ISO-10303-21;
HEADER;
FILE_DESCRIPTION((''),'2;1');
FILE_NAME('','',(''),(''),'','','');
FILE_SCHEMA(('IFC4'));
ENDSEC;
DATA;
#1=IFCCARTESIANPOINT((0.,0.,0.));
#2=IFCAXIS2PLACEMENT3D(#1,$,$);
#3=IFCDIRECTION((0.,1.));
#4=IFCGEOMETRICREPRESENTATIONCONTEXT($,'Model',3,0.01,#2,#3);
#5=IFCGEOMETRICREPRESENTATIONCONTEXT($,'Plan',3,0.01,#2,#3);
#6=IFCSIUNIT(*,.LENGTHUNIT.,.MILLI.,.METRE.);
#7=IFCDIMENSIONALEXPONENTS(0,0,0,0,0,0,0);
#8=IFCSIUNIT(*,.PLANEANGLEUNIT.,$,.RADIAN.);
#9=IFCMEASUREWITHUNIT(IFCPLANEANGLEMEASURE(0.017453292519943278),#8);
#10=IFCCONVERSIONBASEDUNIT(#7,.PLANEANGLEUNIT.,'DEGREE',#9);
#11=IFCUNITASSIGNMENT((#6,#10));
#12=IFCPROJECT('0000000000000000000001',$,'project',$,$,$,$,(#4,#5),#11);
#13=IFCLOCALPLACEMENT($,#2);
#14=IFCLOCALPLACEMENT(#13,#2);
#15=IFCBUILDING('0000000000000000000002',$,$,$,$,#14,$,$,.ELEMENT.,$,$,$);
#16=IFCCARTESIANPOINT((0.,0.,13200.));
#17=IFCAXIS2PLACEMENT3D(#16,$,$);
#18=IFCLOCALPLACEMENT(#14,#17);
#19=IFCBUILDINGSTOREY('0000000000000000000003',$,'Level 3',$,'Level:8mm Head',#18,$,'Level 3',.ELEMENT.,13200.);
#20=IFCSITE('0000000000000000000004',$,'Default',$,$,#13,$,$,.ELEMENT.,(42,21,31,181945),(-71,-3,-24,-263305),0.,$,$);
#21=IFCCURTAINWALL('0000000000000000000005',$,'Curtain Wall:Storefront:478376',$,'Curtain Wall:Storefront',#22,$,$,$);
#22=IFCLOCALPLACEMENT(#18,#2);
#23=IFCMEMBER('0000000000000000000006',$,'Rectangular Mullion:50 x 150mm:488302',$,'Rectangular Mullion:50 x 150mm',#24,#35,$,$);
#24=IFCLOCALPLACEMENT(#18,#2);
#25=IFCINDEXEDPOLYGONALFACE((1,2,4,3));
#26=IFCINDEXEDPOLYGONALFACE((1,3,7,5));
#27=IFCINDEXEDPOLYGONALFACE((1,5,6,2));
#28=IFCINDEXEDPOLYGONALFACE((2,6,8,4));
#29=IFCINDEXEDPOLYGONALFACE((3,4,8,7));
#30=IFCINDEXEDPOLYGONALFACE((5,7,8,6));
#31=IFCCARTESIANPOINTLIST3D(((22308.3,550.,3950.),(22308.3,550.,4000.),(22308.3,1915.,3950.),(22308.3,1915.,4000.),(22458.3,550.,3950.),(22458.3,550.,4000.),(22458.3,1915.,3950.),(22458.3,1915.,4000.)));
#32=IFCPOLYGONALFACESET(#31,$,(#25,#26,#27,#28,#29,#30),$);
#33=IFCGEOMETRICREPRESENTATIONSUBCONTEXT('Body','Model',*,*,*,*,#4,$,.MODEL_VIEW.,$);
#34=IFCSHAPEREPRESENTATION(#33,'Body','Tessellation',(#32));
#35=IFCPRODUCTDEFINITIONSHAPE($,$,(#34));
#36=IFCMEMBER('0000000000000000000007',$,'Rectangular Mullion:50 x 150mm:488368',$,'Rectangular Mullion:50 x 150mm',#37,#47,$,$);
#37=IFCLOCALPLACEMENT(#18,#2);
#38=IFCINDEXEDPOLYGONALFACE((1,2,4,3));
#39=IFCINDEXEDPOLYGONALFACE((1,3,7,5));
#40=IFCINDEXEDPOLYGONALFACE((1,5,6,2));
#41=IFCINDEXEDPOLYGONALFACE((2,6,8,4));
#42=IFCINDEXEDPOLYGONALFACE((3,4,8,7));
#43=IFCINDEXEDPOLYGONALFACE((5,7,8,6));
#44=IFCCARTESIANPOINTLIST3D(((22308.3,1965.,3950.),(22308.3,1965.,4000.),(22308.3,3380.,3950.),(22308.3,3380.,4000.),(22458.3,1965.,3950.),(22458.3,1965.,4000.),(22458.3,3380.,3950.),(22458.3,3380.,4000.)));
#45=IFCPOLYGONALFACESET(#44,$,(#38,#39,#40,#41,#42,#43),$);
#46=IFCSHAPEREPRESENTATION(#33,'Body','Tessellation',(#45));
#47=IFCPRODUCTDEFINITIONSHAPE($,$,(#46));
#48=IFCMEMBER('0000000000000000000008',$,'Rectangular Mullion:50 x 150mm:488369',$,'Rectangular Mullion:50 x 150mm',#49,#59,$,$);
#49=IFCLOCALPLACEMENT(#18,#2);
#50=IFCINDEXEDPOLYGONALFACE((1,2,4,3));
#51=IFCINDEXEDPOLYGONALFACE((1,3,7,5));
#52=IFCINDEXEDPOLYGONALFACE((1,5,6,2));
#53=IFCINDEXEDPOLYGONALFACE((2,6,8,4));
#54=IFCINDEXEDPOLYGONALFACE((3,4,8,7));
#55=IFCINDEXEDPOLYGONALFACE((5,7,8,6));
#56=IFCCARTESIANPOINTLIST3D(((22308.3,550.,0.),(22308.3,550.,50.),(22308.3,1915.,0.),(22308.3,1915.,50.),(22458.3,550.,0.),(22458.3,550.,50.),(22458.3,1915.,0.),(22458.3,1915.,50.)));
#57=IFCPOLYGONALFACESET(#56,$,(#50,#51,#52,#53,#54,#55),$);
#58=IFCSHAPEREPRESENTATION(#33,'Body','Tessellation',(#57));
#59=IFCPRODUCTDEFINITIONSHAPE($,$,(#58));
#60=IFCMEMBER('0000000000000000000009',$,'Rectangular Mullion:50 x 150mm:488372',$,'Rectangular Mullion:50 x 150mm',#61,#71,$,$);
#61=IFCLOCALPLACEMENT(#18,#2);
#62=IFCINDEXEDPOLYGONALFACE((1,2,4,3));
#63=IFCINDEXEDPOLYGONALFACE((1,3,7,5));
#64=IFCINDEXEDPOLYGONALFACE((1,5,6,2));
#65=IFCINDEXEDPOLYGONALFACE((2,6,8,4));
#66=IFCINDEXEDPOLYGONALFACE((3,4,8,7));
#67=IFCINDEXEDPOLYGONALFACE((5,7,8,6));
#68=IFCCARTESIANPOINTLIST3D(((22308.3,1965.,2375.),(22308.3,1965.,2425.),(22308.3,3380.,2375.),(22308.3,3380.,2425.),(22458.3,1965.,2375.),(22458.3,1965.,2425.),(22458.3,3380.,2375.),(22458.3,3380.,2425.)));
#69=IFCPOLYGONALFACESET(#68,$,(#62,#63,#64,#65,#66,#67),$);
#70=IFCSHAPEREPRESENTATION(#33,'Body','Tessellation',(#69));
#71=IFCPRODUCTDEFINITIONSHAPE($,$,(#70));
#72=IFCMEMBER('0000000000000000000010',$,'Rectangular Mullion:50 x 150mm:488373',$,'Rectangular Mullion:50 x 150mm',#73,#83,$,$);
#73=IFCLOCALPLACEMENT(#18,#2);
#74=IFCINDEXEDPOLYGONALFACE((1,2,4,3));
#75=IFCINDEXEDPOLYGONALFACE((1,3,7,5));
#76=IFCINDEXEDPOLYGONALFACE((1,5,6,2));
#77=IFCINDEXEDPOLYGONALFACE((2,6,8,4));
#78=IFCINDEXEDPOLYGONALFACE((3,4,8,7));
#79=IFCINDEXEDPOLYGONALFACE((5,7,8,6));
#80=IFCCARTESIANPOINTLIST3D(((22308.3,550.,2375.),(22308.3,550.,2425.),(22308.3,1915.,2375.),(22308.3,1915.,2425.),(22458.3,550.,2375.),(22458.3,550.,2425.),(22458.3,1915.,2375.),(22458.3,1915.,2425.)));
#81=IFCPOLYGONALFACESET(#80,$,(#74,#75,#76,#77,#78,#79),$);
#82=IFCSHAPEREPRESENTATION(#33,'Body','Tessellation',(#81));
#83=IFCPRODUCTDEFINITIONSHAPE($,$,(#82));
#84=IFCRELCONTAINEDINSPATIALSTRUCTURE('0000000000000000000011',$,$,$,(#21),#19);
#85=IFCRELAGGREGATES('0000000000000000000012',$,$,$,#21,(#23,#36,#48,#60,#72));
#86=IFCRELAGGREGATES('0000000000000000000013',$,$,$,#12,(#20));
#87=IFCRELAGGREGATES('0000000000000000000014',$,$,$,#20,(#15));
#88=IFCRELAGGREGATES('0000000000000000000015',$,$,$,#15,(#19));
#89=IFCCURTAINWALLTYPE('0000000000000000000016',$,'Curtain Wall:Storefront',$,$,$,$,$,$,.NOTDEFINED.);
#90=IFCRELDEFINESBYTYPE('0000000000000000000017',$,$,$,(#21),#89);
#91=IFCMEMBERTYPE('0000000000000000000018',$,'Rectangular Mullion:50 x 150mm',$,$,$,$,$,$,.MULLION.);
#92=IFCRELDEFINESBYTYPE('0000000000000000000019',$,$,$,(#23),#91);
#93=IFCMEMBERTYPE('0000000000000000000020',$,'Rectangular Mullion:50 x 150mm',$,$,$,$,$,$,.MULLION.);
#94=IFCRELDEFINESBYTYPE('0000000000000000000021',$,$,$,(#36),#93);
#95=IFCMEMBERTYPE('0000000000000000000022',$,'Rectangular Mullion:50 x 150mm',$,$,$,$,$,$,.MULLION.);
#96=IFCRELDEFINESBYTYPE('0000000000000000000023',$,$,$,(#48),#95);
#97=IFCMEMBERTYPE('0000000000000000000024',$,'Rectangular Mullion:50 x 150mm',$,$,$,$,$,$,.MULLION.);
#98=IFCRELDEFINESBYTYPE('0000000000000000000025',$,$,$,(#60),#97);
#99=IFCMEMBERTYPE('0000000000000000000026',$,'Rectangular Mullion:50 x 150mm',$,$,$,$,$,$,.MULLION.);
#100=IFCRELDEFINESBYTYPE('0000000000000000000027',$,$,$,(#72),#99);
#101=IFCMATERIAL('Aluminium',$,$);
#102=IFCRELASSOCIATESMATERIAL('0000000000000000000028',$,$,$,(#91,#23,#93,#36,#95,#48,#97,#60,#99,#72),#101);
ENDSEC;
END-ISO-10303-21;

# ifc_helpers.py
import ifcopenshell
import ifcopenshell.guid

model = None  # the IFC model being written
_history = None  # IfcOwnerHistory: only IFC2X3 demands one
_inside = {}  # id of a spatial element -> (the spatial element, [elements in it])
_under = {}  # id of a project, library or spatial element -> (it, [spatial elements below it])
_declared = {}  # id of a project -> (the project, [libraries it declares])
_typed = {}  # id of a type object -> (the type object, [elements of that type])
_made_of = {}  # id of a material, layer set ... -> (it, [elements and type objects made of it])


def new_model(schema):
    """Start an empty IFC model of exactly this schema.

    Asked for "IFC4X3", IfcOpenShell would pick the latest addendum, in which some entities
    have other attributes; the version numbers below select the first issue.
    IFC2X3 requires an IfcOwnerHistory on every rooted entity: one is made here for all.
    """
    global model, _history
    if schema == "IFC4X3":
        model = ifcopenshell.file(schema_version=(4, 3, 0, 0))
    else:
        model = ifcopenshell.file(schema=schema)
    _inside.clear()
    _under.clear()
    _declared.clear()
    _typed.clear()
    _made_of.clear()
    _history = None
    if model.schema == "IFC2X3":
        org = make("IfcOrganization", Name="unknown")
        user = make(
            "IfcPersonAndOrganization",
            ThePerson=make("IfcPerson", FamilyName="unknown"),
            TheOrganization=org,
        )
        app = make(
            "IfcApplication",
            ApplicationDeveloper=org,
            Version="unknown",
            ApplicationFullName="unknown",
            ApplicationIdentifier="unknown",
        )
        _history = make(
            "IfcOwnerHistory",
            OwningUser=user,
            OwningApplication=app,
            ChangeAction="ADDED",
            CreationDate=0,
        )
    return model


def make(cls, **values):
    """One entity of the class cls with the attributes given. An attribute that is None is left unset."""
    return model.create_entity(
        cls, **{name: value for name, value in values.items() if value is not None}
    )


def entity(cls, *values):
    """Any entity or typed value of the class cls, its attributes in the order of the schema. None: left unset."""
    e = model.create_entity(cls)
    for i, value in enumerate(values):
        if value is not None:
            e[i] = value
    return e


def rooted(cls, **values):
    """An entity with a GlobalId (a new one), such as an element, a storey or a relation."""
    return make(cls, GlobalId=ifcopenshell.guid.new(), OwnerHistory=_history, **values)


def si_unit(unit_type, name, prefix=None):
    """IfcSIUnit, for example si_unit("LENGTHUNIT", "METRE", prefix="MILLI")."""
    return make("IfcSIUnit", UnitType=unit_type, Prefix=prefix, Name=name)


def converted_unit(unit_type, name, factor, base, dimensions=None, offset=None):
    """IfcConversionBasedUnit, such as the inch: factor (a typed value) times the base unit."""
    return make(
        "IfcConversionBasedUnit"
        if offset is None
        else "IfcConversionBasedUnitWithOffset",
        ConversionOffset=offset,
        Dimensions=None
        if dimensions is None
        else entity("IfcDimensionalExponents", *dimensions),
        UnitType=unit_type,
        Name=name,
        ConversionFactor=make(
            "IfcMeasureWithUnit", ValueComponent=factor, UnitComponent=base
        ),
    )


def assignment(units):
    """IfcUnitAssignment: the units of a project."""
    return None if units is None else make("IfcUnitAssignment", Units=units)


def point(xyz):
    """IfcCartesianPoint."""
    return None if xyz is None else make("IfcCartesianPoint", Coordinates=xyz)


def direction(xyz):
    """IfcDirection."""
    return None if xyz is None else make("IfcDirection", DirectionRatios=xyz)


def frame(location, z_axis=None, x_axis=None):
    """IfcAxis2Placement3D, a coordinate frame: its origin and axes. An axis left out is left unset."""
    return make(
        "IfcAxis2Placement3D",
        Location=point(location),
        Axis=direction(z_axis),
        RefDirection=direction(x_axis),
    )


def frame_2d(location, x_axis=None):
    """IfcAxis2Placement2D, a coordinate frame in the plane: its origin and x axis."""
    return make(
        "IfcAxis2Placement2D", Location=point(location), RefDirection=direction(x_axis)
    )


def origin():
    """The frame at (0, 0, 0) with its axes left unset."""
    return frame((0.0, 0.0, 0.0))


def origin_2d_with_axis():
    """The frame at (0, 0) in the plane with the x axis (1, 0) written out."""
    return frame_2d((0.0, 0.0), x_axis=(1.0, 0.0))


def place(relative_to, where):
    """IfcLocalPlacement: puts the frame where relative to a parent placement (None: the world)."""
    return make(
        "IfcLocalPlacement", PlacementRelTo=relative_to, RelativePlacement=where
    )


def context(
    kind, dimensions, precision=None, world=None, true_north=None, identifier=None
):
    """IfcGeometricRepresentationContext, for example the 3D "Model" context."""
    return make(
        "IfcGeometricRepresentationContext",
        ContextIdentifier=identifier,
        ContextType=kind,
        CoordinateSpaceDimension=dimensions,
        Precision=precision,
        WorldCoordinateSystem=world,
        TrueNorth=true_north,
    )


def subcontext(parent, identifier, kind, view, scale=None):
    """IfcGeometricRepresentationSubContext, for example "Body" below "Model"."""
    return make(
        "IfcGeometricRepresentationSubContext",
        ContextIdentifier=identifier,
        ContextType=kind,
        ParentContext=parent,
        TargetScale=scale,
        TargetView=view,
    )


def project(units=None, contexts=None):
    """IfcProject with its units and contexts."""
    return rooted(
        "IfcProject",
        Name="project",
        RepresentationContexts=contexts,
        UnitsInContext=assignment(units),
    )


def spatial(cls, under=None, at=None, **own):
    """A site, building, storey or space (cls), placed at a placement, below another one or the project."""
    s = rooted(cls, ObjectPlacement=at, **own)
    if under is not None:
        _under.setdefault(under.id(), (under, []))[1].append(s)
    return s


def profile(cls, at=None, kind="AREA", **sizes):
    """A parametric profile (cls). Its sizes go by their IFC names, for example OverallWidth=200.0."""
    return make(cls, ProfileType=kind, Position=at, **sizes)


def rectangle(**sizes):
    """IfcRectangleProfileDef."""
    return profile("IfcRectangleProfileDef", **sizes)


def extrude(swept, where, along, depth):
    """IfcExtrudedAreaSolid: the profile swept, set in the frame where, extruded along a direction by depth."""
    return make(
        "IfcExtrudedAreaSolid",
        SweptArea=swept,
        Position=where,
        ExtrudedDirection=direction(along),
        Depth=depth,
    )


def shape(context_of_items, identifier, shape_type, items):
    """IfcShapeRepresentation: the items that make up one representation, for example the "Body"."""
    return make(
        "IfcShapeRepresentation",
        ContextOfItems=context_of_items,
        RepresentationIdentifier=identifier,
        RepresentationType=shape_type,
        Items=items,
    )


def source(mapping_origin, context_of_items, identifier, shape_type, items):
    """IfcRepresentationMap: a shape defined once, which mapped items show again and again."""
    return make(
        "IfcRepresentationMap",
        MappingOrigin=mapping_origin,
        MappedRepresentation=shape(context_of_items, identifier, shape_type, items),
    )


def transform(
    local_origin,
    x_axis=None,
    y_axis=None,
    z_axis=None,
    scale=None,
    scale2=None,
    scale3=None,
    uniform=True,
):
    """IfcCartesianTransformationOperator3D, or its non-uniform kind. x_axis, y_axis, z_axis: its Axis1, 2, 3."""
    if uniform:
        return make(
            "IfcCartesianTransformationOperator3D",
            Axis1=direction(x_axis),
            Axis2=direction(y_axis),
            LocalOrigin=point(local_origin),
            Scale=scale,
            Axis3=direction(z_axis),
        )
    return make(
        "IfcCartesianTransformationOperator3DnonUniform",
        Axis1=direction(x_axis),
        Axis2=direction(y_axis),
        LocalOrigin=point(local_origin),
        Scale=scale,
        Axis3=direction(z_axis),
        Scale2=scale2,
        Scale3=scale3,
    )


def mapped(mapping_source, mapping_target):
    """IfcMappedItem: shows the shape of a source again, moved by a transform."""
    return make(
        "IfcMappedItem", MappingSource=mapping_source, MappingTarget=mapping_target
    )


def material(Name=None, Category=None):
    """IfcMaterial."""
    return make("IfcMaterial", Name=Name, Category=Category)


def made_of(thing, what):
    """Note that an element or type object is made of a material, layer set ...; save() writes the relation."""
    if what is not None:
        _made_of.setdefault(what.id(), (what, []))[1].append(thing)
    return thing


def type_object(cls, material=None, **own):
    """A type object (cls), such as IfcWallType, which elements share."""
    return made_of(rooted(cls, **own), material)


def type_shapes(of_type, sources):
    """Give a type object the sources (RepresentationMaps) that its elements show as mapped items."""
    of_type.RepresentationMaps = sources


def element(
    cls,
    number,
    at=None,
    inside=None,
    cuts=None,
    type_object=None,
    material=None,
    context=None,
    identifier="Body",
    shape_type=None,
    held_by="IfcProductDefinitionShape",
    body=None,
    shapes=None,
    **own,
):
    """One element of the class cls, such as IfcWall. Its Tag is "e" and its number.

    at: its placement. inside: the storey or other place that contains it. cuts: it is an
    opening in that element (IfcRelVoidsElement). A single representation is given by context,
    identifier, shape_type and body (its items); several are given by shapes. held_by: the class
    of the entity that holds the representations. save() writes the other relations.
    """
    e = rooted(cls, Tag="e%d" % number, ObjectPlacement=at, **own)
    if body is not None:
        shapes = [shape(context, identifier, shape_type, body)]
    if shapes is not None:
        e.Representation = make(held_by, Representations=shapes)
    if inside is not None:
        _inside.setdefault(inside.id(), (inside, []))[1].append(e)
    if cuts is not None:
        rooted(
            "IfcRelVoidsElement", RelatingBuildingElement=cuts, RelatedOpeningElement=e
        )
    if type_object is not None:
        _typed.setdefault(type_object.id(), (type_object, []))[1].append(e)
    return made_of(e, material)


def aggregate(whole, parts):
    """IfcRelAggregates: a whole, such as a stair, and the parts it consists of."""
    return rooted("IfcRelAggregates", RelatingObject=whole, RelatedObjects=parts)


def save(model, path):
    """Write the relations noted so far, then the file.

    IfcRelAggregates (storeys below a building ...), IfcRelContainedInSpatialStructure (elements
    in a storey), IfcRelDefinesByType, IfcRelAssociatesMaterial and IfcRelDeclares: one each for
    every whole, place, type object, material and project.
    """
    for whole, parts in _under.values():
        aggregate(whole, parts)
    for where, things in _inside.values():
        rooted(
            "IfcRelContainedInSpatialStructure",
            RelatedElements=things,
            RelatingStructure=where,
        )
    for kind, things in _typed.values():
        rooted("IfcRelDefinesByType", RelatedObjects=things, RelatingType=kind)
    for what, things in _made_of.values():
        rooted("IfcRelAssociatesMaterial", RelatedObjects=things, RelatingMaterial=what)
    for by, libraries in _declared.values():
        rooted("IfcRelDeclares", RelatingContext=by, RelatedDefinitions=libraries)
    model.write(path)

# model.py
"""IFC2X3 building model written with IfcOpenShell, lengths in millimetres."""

from ifc_helpers import new_model, entity, si_unit, converted_unit, direction, frame, origin, origin_2d_with_axis, place, context, subcontext, project, spatial, rectangle, extrude, source, transform, mapped, material, type_object, type_shapes, element, aggregate, save


model = new_model("IFC2X3")

# Units and contexts
model_context = context("Model", 3, precision=0.01, world=origin(), true_north=direction((0.0, 1.0)))
plan_context = context("Plan", 3, precision=0.01, world=origin(), true_north=direction((0.0, 1.0)))
body_context = subcontext(model_context, "Body", "Model", "MODEL_VIEW")
ifc_project = project(units=[si_unit("LENGTHUNIT", "METRE", prefix="MILLI"), converted_unit("PLANEANGLEUNIT", "DEGREE", entity("IfcPlaneAngleMeasure", 0.017453292519943278), si_unit("PLANEANGLEUNIT", "RADIAN"), dimensions=[0, 0, 0, 0, 0, 0, 0])], contexts=[model_context, plan_context])

# Site, building, storey
site_placement = place(None, origin())
site = spatial("IfcSite", under=ifc_project, at=site_placement, Name="Default", CompositionType="ELEMENT", RefLatitude=(42, 21, 31, 181945), RefLongitude=(-71, -3, -24, -263305), RefElevation=0.0)
building_placement = place(site_placement, origin())
building = spatial("IfcBuilding", under=site, at=building_placement, CompositionType="ELEMENT")
storey_placement = place(building_placement, frame((0.0, 0.0, 13200.0)))
storey = spatial("IfcBuildingStorey", under=building, at=storey_placement, Name="Level 3", ObjectType="Level:8mm Head", LongName="Level 3", CompositionType="ELEMENT", Elevation=13200.0)

# Curtain wall
curtain_wall_type = type_object("IfcCurtainWallType", Name="Curtain Wall:Storefront", PredefinedType="NOTDEFINED")
curtain_wall_1_placement = place(storey_placement, frame((0.0, 0.0, -13200.0)))
curtain_wall_1 = element("IfcCurtainWall", 1, at=curtain_wall_1_placement, inside=storey, type_object=curtain_wall_type, Name="Curtain Wall:Storefront:478376", ObjectType="Curtain Wall:Storefront")
ifc_material_1 = material(Name="Aluminium")

# Members
member_type_1 = type_object("IfcMemberType", Name="Rectangular Mullion:50 x 150mm", PredefinedType="MULLION", material=ifc_material_1)
shared_shape_1 = source(origin(), body_context, "Body", "SweptSolid", [
    extrude(rectangle(XDim=50.0, YDim=150.0, at=origin_2d_with_axis()), frame((-25.0, 0.0, -1365.0), z_axis=(0.0, 0.0, 1.0), x_axis=(-1.0, 0.0, 0.0)), (0.0, 0.0, 1.0), 1365.0),
])
type_shapes(member_type_1, [shared_shape_1])
member_1_placement = place(curtain_wall_1_placement, frame((22383.3, 550.0, 17200.0), z_axis=(0.0, -1.0, 0.0), x_axis=(0.0, 0.0, 1.0)))
member_1 = element("IfcMember", 2, at=member_1_placement, type_object=member_type_1, material=ifc_material_1, Name="Rectangular Mullion:50 x 150mm:488302", ObjectType="Rectangular Mullion:50 x 150mm", context=body_context, shape_type="MappedRepresentation", body=[
    mapped(shared_shape_1, transform((0.0, 0.0, 0.0), scale=1.0)),
])
member_type_2 = type_object("IfcMemberType", Name="Rectangular Mullion:50 x 150mm", PredefinedType="MULLION", material=ifc_material_1)
shared_shape_2 = source(origin(), body_context, "Body", "SweptSolid", [
    extrude(rectangle(XDim=50.0, YDim=150.0, at=origin_2d_with_axis()), frame((-25.0, 0.0, -1415.0), z_axis=(0.0, 0.0, 1.0), x_axis=(-1.0, 0.0, 0.0)), (0.0, 0.0, 1.0), 1415.0),
])
type_shapes(member_type_2, [shared_shape_2])
member_2_placement = place(curtain_wall_1_placement, frame((22383.3, 1965.0, 17200.0), z_axis=(0.0, -1.0, 0.0), x_axis=(0.0, 0.0, 1.0)))
member_2 = element("IfcMember", 3, at=member_2_placement, type_object=member_type_2, material=ifc_material_1, Name="Rectangular Mullion:50 x 150mm:488368", ObjectType="Rectangular Mullion:50 x 150mm", context=body_context, shape_type="MappedRepresentation", body=[
    mapped(shared_shape_2, transform((0.0, 0.0, 0.0), scale=1.0)),
])
member_type_3 = type_object("IfcMemberType", Name="Rectangular Mullion:50 x 150mm", PredefinedType="MULLION", material=ifc_material_1)
shared_shape_3 = source(origin(), body_context, "Body", "SweptSolid", [
    extrude(rectangle(XDim=50.0, YDim=150.0, at=origin_2d_with_axis()), frame((-25.0, 0.0, -1365.0), z_axis=(0.0, 0.0, 1.0), x_axis=(-1.0, 0.0, 0.0)), (0.0, 0.0, 1.0), 1365.0),
])
type_shapes(member_type_3, [shared_shape_3])
member_3_placement = place(curtain_wall_1_placement, frame((22383.3, 1915.0, 13200.0), z_axis=(0.0, 1.0, 0.0), x_axis=(0.0, 0.0, -1.0)))
member_3 = element("IfcMember", 4, at=member_3_placement, type_object=member_type_3, material=ifc_material_1, Name="Rectangular Mullion:50 x 150mm:488369", ObjectType="Rectangular Mullion:50 x 150mm", context=body_context, shape_type="MappedRepresentation", body=[
    mapped(shared_shape_3, transform((0.0, 0.0, 0.0), scale=1.0)),
])
member_type_4 = type_object("IfcMemberType", Name="Rectangular Mullion:50 x 150mm", PredefinedType="MULLION", material=ifc_material_1)
shared_shape_4 = source(origin(), body_context, "Body", "SweptSolid", [
    extrude(rectangle(XDim=50.0, YDim=150.0, at=origin_2d_with_axis()), frame((0.0, 0.0, -1415.0), z_axis=(0.0, 0.0, 1.0), x_axis=(-1.0, 0.0, 0.0)), (0.0, 0.0, 1.0), 1415.0),
])
type_shapes(member_type_4, [shared_shape_4])
member_4_placement = place(curtain_wall_1_placement, frame((22383.3, 1965.0, 15600.0), z_axis=(0.0, -1.0, 0.0), x_axis=(0.0, 0.0, 1.0)))
member_4 = element("IfcMember", 5, at=member_4_placement, type_object=member_type_4, material=ifc_material_1, Name="Rectangular Mullion:50 x 150mm:488372", ObjectType="Rectangular Mullion:50 x 150mm", context=body_context, shape_type="MappedRepresentation", body=[
    mapped(shared_shape_4, transform((0.0, 0.0, 0.0), scale=1.0)),
])
member_type_5 = type_object("IfcMemberType", Name="Rectangular Mullion:50 x 150mm", PredefinedType="MULLION", material=ifc_material_1)
shared_shape_5 = source(origin(), body_context, "Body", "SweptSolid", [
    extrude(rectangle(XDim=50.0, YDim=150.0, at=origin_2d_with_axis()), frame((0.0, 0.0, -1365.0), z_axis=(0.0, 0.0, 1.0), x_axis=(-1.0, 0.0, 0.0)), (0.0, 0.0, 1.0), 1365.0),
])
type_shapes(member_type_5, [shared_shape_5])
member_5_placement = place(curtain_wall_1_placement, frame((22383.3, 550.0, 15600.0), z_axis=(0.0, -1.0, 0.0), x_axis=(0.0, 0.0, 1.0)))
member_5 = element("IfcMember", 6, at=member_5_placement, type_object=member_type_5, material=ifc_material_1, Name="Rectangular Mullion:50 x 150mm:488373", ObjectType="Rectangular Mullion:50 x 150mm", context=body_context, shape_type="MappedRepresentation", body=[
    mapped(shared_shape_5, transform((0.0, 0.0, 0.0), scale=1.0)),
])

aggregate(curtain_wall_1, [member_1, member_2, member_3, member_4, member_5])

save(model, "model.ifc")
